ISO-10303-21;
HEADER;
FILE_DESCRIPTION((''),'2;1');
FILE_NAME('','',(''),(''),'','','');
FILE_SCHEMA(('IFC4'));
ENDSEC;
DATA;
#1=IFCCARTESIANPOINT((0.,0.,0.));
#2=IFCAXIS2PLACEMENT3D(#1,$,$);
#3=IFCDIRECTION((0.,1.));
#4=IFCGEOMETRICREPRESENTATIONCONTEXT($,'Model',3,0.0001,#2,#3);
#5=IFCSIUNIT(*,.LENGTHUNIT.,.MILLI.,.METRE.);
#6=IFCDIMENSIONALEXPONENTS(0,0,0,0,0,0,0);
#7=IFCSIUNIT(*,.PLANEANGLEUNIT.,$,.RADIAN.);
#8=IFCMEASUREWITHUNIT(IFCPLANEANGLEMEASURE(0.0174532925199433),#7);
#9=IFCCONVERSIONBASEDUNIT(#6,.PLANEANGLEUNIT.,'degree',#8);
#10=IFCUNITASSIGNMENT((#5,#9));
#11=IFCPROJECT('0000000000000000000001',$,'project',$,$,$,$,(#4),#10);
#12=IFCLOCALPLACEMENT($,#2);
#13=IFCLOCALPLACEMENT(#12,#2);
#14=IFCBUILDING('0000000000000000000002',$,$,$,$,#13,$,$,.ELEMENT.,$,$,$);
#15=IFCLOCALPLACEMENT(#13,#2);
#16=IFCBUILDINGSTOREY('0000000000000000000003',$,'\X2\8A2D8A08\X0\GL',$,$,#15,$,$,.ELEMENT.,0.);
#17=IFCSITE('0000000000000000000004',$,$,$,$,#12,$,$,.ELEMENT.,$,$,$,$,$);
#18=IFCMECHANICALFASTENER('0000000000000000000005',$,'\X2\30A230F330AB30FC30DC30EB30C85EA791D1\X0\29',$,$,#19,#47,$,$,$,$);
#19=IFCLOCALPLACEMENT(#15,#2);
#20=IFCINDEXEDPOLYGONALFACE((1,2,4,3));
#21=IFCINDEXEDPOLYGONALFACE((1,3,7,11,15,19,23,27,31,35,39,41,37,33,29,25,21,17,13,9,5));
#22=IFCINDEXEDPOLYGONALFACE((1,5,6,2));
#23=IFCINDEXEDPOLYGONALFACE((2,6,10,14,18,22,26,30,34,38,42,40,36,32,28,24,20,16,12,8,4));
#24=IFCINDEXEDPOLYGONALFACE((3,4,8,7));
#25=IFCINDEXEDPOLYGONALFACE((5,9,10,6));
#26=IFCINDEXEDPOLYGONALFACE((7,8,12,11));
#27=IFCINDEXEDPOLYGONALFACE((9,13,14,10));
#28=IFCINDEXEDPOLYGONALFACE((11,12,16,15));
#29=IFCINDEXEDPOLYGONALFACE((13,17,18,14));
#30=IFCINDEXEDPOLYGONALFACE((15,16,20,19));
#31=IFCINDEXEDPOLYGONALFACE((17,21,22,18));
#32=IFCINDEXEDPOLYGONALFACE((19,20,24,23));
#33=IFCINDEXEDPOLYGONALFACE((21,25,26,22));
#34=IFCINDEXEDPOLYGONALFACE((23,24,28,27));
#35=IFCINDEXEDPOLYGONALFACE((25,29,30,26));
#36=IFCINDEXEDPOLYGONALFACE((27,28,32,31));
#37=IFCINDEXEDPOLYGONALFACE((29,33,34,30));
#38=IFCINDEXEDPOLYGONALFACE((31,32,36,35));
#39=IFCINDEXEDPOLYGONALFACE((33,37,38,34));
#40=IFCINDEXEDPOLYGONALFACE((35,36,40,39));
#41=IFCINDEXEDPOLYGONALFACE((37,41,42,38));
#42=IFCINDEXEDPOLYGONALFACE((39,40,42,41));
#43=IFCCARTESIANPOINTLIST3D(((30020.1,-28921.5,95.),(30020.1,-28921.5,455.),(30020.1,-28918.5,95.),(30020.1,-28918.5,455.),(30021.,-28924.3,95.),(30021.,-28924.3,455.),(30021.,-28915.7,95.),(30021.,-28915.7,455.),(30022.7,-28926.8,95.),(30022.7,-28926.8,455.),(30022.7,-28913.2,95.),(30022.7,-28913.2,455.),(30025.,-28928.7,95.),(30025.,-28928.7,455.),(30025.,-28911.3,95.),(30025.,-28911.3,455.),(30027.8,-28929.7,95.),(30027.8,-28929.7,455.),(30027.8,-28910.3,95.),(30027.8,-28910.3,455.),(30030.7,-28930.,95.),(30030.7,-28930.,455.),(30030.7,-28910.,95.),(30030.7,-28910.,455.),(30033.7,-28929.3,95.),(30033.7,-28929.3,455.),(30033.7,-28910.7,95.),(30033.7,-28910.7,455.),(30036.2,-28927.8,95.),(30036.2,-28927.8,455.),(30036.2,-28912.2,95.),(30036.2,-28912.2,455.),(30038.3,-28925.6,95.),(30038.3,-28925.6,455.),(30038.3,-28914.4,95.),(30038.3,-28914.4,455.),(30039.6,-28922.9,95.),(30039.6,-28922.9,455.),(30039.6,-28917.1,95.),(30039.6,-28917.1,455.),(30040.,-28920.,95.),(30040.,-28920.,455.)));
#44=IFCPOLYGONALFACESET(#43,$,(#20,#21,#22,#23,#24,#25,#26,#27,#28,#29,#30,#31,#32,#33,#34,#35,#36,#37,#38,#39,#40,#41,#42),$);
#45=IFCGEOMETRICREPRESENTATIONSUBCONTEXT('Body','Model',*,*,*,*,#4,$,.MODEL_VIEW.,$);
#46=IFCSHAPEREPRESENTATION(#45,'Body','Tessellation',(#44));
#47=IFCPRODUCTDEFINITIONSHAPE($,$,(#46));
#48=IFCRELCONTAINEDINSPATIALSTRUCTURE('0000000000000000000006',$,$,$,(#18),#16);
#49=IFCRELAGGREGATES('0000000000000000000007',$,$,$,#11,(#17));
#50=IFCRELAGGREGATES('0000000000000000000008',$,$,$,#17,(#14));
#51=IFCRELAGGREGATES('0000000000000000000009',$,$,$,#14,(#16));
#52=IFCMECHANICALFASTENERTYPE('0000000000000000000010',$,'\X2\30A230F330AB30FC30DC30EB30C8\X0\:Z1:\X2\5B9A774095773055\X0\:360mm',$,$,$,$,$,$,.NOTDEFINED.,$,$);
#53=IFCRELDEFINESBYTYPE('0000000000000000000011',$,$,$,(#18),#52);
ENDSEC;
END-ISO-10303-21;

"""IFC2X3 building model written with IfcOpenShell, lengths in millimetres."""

from ifc_helpers import new_model, entity, si_unit, converted_unit, direction, frame, origin, origin_with_axes, origin_2d, place, context, subcontext, project, spatial, circle, extrude, type_object, element, save


model = new_model("IFC2X3")

# Units and contexts
model_context = context("Model", 3, precision=0.0001, world=origin(), true_north=direction((0.0, 1.0)))
body_context = subcontext(model_context, "Body", "Model", "MODEL_VIEW")
ifc_project = project(units=[si_unit("LENGTHUNIT", "METRE", prefix="MILLI"), converted_unit("PLANEANGLEUNIT", "degree", entity("IfcPlaneAngleMeasure", 0.0174532925199433), si_unit("PLANEANGLEUNIT", "RADIAN"), dimensions=[0, 0, 0, 0, 0, 0, 0])], contexts=[model_context])

# Site, building, storey
site_placement = place(None, origin())
site = spatial("IfcSite", under=ifc_project, at=site_placement, CompositionType="ELEMENT")
building_placement = place(site_placement, origin())
building = spatial("IfcBuilding", under=site, at=building_placement, CompositionType="ELEMENT")
storey_placement = place(building_placement, origin())
storey = spatial("IfcBuildingStorey", under=building, at=storey_placement, Name="設計GL", CompositionType="ELEMENT", Elevation=0.0)

# Mechanical fastener
mechanical_fastener_type_1 = type_object("IfcMechanicalFastenerType", Name="アンカーボルト:Z1:定着長さ:360mm")
mechanical_fastener_1_placement = place(storey_placement, frame((30030.0, -28920.0, 95.0)))
element("IfcMechanicalFastener", 1, at=mechanical_fastener_1_placement, inside=storey, type_object=mechanical_fastener_type_1, Name="アンカーボルト座金29", context=body_context, shape_type="SweptSolid", body=[
    extrude(circle(Radius=10.0, at=origin_2d()), origin_with_axes(), (0.0, 0.0, 1.0), 360.0),
])

save(model, "model.ifc")
